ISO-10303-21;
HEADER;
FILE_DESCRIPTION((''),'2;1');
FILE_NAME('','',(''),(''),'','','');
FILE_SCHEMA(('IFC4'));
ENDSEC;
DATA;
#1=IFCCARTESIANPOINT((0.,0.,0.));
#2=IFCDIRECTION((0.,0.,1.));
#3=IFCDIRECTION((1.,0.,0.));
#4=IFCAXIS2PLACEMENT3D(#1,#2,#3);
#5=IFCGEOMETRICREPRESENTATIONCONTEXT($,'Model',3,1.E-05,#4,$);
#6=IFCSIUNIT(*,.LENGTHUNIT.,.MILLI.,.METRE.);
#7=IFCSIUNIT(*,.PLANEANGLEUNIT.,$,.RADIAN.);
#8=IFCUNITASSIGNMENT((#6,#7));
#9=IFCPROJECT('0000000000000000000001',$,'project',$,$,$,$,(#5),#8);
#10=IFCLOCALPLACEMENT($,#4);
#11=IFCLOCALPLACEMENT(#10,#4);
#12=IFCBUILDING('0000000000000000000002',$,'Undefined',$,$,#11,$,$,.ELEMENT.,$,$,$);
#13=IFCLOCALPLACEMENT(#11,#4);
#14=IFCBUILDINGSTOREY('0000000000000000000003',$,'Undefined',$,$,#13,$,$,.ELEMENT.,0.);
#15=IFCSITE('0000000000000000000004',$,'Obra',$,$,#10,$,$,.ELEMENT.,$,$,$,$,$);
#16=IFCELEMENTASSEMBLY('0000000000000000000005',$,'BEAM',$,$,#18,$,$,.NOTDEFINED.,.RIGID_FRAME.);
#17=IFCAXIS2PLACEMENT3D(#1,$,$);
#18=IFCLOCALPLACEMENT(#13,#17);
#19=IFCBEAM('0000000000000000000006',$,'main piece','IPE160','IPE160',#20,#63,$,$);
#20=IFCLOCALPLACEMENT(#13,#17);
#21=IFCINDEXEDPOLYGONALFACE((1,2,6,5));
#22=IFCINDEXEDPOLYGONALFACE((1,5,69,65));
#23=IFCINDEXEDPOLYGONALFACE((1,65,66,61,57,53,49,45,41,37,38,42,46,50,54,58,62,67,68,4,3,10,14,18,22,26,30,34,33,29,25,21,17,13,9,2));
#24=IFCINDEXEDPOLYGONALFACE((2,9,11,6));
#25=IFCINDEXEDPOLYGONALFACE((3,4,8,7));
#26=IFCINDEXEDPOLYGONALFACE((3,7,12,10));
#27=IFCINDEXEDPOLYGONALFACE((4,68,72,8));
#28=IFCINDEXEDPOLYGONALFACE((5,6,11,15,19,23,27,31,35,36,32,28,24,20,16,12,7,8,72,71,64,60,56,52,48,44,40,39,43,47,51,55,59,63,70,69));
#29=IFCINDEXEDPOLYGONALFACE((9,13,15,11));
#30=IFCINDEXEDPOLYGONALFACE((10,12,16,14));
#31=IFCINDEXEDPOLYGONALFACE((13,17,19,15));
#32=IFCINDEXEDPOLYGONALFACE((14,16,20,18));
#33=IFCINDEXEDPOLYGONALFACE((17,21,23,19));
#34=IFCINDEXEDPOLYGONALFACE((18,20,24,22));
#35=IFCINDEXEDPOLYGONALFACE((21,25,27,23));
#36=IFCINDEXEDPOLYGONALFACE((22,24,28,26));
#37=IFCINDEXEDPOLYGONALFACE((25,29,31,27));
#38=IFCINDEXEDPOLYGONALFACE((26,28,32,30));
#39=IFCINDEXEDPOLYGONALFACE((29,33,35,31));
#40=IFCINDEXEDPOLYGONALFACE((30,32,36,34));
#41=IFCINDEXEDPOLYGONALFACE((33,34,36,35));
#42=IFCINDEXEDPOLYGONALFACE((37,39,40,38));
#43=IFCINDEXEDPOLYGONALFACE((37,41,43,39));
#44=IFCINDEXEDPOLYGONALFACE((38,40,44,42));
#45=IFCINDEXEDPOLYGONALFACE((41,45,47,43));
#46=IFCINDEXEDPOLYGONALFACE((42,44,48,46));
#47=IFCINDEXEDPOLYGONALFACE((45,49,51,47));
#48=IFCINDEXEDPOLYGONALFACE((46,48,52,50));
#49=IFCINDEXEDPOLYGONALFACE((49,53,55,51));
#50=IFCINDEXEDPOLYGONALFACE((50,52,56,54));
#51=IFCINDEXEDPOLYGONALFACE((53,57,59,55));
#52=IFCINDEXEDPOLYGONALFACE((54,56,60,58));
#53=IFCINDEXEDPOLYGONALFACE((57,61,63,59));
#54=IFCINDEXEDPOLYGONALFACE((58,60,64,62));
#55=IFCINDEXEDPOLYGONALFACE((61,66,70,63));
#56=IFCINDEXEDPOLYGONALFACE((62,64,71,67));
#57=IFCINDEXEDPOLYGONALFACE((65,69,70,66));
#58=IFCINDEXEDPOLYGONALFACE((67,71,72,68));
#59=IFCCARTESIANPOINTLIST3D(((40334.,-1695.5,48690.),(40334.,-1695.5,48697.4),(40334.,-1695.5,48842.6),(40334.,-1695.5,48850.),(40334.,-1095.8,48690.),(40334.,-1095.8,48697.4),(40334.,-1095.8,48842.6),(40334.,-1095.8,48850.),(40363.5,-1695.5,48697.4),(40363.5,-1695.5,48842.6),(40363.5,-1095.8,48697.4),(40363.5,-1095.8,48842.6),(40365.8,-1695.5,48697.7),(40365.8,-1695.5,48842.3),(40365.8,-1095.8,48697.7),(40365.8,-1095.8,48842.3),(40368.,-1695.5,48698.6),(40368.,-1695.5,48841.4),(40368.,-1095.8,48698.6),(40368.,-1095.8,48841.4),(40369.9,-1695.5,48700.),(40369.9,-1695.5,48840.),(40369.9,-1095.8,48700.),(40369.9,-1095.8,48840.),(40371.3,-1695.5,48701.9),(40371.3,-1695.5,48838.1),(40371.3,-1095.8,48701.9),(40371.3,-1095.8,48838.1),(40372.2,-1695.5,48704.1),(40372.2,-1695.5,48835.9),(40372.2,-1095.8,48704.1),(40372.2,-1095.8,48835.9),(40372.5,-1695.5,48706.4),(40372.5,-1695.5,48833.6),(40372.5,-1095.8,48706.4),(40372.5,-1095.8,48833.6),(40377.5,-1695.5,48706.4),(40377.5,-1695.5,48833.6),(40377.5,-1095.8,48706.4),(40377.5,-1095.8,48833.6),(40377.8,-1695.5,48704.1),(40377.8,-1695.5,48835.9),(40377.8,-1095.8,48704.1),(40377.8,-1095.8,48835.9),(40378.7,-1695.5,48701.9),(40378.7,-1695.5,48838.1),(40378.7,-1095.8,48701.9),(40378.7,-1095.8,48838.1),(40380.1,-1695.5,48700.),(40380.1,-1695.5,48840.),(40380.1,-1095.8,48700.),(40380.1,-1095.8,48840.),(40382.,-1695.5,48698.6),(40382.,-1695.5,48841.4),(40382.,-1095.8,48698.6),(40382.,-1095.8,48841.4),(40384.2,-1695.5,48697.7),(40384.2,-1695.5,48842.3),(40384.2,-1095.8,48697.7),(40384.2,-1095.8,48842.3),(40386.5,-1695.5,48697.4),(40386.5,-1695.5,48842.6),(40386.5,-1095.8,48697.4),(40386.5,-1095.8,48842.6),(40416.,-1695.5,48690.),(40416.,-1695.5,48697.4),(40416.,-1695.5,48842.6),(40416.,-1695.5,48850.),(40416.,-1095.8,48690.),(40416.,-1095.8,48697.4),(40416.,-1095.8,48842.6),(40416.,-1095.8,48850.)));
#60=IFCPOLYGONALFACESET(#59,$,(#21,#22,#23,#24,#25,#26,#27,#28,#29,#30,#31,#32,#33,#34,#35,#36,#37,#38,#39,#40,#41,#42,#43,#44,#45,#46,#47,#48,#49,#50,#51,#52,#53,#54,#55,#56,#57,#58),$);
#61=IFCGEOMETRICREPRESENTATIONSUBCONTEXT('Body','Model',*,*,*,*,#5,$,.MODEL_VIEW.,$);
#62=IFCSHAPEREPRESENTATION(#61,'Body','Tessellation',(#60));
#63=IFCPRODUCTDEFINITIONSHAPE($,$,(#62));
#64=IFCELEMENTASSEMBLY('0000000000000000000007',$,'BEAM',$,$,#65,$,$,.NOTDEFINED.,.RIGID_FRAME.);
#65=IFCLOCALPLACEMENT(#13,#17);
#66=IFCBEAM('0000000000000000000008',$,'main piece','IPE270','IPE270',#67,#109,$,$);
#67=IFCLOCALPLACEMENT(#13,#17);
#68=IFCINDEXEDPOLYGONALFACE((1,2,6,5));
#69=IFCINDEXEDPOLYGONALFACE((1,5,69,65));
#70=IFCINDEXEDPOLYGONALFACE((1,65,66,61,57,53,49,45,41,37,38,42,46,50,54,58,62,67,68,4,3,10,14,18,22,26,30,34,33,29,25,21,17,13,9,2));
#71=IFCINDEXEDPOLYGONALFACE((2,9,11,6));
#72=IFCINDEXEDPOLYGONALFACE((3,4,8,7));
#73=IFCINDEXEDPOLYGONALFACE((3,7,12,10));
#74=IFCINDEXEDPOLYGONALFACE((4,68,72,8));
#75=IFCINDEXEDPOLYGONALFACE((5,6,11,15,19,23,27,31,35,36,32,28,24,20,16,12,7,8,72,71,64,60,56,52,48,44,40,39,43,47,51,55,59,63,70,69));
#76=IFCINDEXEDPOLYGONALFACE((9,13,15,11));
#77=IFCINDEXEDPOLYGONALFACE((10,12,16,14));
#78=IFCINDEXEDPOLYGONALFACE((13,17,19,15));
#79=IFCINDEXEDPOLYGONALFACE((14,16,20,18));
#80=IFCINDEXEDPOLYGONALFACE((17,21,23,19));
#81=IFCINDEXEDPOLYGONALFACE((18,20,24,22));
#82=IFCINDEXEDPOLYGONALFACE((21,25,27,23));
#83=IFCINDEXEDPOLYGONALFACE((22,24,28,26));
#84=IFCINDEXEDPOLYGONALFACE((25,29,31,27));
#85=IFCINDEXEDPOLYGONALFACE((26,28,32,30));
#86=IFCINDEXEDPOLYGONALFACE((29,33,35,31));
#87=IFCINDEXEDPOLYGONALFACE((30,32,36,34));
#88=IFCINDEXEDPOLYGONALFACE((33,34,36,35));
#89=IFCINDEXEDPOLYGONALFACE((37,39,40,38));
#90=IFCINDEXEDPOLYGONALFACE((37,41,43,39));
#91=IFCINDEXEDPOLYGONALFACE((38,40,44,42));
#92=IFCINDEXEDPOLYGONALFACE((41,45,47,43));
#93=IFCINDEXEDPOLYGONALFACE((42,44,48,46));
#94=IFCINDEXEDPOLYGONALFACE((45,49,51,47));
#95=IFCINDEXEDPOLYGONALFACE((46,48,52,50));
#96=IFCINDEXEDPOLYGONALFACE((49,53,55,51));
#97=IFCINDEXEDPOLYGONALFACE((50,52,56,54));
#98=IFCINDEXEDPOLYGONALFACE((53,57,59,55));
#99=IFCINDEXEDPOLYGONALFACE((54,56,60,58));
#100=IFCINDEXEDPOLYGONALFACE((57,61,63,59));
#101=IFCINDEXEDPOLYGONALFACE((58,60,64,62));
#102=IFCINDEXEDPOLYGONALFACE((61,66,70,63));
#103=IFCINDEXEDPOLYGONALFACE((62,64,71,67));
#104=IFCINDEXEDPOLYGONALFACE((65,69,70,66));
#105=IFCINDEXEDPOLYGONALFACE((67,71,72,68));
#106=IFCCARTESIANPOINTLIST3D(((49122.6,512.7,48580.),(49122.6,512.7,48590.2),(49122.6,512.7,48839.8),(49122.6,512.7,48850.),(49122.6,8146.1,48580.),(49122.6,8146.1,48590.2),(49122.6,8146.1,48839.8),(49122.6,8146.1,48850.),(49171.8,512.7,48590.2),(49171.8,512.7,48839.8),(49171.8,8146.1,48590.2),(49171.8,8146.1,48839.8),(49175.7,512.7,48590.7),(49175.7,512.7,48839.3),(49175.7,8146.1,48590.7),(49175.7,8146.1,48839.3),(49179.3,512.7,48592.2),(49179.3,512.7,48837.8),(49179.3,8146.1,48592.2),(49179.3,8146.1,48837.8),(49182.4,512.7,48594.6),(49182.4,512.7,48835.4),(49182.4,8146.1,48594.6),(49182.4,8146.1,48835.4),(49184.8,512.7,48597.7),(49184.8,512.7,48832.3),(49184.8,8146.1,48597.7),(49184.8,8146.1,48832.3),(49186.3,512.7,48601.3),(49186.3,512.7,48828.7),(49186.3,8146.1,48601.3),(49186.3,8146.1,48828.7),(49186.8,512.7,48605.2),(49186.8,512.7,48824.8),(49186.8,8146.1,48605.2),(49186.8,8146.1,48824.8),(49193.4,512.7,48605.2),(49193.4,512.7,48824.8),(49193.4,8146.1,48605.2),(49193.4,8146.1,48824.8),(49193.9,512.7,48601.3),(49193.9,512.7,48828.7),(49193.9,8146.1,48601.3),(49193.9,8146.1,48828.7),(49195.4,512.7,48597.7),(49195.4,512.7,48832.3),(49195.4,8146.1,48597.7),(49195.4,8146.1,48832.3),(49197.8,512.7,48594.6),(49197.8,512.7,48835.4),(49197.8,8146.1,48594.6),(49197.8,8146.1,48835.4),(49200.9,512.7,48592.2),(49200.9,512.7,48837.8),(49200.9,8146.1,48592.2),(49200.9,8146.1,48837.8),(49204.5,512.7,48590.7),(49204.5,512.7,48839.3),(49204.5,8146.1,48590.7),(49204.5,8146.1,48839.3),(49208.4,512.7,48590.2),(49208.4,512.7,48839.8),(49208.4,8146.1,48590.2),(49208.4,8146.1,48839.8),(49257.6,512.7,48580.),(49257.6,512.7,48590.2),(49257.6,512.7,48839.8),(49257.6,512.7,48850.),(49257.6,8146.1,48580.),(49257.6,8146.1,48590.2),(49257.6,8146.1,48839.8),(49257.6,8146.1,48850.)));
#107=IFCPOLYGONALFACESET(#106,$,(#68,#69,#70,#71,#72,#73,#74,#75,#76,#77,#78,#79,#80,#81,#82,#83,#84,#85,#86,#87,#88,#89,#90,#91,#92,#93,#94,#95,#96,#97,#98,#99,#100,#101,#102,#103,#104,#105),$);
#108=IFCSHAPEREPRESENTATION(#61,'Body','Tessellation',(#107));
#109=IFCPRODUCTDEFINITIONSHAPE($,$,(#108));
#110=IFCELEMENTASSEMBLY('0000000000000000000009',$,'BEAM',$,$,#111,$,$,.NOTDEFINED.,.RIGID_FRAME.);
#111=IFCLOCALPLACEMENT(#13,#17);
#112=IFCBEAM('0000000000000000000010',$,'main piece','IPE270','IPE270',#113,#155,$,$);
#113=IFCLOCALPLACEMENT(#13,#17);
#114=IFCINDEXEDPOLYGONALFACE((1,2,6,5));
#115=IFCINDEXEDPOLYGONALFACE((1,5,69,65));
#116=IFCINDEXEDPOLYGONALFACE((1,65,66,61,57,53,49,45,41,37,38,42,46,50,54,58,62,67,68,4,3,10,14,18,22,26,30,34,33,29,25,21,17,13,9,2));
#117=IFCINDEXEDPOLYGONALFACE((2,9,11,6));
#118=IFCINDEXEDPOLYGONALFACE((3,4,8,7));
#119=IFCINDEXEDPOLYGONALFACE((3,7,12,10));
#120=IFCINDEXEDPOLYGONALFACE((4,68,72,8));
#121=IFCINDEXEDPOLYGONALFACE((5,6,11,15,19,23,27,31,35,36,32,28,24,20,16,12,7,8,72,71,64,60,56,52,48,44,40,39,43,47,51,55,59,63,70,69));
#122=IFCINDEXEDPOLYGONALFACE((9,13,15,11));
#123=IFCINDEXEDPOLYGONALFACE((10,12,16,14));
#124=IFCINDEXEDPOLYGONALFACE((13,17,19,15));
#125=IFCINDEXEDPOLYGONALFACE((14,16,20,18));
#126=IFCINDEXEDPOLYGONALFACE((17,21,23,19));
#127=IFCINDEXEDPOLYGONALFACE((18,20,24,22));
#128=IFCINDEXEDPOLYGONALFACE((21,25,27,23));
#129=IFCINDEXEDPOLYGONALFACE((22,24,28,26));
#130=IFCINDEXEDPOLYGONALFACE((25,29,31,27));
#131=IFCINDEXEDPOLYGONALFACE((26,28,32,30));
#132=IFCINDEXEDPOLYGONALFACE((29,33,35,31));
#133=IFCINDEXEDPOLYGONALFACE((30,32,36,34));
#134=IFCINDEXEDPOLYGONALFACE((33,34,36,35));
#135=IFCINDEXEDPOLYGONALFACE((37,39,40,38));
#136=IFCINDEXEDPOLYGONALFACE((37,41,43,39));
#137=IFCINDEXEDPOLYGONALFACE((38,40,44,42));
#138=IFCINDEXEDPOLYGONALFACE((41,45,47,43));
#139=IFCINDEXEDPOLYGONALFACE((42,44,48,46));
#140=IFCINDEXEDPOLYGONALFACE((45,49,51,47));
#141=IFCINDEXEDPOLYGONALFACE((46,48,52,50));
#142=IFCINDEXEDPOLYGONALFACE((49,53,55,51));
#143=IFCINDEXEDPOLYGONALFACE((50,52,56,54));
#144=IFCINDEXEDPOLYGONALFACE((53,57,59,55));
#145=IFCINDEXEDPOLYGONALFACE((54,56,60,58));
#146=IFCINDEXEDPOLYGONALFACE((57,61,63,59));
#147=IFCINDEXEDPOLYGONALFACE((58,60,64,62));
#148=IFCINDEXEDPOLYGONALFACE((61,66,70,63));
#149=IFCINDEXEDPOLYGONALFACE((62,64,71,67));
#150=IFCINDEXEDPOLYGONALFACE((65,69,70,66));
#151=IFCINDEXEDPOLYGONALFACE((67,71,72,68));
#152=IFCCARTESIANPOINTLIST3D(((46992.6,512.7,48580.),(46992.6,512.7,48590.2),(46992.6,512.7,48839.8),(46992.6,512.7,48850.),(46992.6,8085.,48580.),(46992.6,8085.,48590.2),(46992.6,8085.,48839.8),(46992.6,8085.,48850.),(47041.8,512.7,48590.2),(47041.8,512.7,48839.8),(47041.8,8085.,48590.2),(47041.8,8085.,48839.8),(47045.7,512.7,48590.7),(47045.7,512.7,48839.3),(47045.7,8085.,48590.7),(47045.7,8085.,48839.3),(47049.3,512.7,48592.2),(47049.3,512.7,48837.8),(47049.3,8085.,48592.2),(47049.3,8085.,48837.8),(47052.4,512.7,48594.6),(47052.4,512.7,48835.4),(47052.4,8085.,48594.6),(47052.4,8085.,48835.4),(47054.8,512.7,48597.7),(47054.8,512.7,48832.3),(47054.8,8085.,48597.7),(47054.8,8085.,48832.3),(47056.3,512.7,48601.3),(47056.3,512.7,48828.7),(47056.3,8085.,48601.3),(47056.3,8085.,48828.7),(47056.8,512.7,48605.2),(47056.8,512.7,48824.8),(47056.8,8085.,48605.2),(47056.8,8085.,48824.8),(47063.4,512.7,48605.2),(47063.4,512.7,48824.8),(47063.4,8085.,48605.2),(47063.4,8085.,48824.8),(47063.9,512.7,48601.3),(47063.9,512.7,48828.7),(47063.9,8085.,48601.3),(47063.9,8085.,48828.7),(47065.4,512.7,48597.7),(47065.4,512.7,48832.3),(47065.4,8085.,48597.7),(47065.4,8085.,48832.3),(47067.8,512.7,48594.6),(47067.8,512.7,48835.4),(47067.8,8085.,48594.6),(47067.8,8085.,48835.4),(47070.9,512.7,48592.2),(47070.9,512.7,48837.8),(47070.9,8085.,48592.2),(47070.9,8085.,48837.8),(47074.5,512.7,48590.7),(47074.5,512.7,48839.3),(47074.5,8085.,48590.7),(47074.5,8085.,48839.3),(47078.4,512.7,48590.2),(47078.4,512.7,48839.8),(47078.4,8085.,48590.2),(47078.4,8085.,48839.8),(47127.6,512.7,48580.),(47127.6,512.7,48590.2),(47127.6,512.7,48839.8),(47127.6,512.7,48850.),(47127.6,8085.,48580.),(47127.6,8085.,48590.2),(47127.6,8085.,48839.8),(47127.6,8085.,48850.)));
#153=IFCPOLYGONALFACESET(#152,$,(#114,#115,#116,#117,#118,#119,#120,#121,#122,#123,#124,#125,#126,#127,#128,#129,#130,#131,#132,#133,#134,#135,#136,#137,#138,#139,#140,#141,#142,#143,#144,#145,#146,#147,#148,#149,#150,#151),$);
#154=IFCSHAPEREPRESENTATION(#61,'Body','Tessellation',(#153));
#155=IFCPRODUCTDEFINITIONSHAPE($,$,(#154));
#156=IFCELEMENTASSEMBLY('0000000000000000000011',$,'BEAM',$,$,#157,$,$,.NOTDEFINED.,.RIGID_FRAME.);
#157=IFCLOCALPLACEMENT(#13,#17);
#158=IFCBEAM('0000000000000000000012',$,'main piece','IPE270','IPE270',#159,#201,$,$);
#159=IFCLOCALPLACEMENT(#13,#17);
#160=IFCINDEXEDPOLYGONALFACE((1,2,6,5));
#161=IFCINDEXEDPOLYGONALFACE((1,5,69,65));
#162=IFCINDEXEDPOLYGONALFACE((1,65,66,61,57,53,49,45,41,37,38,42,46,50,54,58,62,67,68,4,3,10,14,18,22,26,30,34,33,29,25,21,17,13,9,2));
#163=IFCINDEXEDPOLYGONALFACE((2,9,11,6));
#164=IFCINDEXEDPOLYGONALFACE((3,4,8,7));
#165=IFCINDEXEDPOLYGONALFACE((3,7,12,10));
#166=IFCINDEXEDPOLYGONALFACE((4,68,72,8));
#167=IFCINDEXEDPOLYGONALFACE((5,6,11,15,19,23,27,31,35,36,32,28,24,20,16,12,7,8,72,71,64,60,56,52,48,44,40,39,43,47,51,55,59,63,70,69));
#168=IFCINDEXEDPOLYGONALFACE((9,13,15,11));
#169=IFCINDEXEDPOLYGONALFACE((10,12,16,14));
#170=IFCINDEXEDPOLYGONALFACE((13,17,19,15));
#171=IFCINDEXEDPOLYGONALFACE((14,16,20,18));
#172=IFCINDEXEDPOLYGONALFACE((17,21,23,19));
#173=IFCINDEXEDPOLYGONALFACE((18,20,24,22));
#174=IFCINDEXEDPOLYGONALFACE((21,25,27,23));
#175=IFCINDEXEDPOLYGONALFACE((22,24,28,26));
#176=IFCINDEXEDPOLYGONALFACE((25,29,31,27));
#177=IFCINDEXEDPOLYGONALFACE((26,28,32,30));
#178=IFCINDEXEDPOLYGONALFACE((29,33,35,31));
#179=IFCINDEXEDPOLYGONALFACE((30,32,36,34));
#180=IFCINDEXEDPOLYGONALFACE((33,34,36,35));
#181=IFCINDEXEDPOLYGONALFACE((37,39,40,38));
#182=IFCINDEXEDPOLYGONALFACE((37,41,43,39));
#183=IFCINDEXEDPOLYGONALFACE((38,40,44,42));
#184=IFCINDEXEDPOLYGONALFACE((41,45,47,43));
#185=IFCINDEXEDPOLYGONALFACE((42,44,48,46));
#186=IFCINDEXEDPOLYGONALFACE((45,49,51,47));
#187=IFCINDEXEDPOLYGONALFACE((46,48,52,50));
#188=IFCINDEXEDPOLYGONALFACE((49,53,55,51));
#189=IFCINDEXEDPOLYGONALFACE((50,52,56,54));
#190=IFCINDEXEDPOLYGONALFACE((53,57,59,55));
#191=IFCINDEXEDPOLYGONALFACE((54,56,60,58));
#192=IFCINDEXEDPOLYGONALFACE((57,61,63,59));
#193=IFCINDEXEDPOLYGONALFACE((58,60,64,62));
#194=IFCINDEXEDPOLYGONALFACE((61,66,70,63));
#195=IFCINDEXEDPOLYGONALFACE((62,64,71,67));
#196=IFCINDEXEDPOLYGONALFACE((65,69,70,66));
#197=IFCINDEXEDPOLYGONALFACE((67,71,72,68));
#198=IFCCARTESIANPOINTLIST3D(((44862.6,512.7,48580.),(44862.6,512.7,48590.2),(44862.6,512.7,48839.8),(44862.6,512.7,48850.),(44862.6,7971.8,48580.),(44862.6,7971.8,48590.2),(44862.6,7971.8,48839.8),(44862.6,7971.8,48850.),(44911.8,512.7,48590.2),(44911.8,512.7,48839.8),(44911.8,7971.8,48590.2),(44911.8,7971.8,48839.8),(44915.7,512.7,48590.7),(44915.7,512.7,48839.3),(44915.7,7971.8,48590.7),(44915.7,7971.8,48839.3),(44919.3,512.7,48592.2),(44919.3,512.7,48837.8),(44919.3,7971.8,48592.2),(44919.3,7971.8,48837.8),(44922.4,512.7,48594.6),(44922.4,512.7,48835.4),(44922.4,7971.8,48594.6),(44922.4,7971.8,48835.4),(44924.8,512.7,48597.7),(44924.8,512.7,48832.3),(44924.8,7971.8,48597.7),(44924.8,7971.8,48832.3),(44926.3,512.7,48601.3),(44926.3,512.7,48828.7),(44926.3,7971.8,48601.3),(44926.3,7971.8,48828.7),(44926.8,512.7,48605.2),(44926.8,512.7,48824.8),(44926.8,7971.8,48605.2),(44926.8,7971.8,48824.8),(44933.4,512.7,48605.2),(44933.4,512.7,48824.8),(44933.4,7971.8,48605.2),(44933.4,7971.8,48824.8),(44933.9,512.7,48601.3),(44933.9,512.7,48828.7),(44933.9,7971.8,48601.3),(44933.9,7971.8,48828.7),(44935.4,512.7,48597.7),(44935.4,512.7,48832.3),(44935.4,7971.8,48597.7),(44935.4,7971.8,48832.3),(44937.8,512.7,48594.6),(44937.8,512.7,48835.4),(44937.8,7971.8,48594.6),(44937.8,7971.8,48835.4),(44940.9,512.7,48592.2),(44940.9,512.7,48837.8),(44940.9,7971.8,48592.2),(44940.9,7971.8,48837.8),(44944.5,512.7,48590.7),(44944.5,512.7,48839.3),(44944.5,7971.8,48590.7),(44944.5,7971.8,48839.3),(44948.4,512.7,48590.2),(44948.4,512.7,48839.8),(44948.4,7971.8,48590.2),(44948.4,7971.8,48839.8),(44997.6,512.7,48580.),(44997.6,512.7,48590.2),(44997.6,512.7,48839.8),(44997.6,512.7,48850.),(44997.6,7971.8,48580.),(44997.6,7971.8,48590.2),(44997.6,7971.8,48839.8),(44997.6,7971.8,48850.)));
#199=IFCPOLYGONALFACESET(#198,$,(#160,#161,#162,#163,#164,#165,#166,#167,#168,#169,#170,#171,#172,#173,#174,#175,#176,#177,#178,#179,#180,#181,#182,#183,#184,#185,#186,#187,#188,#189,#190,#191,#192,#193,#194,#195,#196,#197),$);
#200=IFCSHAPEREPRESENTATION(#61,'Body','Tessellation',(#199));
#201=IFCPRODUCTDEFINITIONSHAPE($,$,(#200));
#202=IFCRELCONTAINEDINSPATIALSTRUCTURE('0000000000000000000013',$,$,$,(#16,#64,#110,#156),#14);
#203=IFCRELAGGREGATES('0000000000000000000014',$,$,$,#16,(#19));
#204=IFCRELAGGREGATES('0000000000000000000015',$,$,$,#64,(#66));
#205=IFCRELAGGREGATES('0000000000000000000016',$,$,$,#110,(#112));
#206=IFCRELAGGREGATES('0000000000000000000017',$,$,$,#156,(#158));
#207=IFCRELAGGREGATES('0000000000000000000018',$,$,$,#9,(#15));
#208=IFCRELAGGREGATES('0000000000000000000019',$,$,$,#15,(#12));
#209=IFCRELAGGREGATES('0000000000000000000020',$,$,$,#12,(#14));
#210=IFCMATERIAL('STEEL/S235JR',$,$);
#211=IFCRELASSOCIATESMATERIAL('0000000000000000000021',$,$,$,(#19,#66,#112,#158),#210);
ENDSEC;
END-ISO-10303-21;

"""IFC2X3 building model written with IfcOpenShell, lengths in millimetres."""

from ifc_helpers import new_model, si_unit, frame, origin_with_axes, origin_2d_with_axis, place, context, subcontext, project, spatial, i_section, extrude, material, element, aggregate, save


model = new_model("IFC2X3")

# Units and contexts
model_context = context("Model", 3, precision=1e-05, world=origin_with_axes())
body_context = subcontext(model_context, "Body", "Model", "MODEL_VIEW")
ifc_project = project(units=[si_unit("LENGTHUNIT", "METRE", prefix="MILLI"), si_unit("PLANEANGLEUNIT", "RADIAN")], contexts=[model_context])

# Site, building, storey
site_placement = place(None, origin_with_axes())
site = spatial("IfcSite", under=ifc_project, at=site_placement, Name="Obra", CompositionType="ELEMENT")
building_placement = place(site_placement, origin_with_axes())
building = spatial("IfcBuilding", under=site, at=building_placement, Name="Undefined", CompositionType="ELEMENT")
storey_placement = place(building_placement, origin_with_axes())
storey = spatial("IfcBuildingStorey", under=building, at=storey_placement, Name="Undefined", CompositionType="ELEMENT", Elevation=0.0)

# Shared definitions
ifc_material_1 = material(Name="STEEL/S235JR")

# Element assemblies, beams
assembly_1_placement = place(storey_placement, origin_with_axes())
assembly_1 = element("IfcElementAssembly", 1, at=assembly_1_placement, inside=storey, Name="BEAM", AssemblyPlace="NOTDEFINED", PredefinedType="RIGID_FRAME")
beam_1_placement = place(assembly_1_placement, frame((40375.0, -1695.5, 48770.0), z_axis=(0.0, 0.0, 1.0), x_axis=(0.0, 1.0, 0.0)))
beam_1 = element("IfcBeam", 2, at=beam_1_placement, material=ifc_material_1, Name="main piece", Description="IPE160", ObjectType="IPE160", context=body_context, shape_type="SweptSolid", body=[
    extrude(i_section(OverallWidth=82.0, OverallDepth=160.0, WebThickness=5.0, FlangeThickness=7.4, FilletRadius=9.0, at=origin_2d_with_axis()), frame((599.7, 0.0, 0.0), z_axis=(-1.0, 0.0, 0.0), x_axis=(0.0, -1.0, 0.0)), (0.0, 0.0, 1.0), 599.7),
])
aggregate(assembly_1, [beam_1])
assembly_2_placement = place(storey_placement, origin_with_axes())
assembly_2 = element("IfcElementAssembly", 3, at=assembly_2_placement, inside=storey, Name="BEAM", AssemblyPlace="NOTDEFINED", PredefinedType="RIGID_FRAME")
beam_2_placement = place(assembly_2_placement, frame((49190.1, 512.7, 48715.0), z_axis=(0.0, 0.0, 1.0), x_axis=(0.0, 1.0, 0.0)))
beam_2 = element("IfcBeam", 4, at=beam_2_placement, material=ifc_material_1, Name="main piece", Description="IPE270", ObjectType="IPE270", context=body_context, shape_type="SweptSolid", body=[
    extrude(i_section(OverallWidth=135.0, OverallDepth=270.0, WebThickness=6.6, FlangeThickness=10.2, FilletRadius=15.0, at=origin_2d_with_axis()), frame((7633.4, 0.0, 0.0), z_axis=(-1.0, 0.0, 0.0), x_axis=(0.0, -1.0, 0.0)), (0.0, 0.0, 1.0), 7633.4),
])
aggregate(assembly_2, [beam_2])
assembly_3_placement = place(storey_placement, origin_with_axes())
assembly_3 = element("IfcElementAssembly", 5, at=assembly_3_placement, inside=storey, Name="BEAM", AssemblyPlace="NOTDEFINED", PredefinedType="RIGID_FRAME")
beam_3_placement = place(assembly_3_placement, frame((47060.1, 8085.0, 48715.0), z_axis=(0.0, 0.0, 1.0), x_axis=(0.0, -1.0, 0.0)))
beam_3 = element("IfcBeam", 6, at=beam_3_placement, material=ifc_material_1, Name="main piece", Description="IPE270", ObjectType="IPE270", context=body_context, shape_type="SweptSolid", body=[
    extrude(i_section(OverallWidth=135.0, OverallDepth=270.0, WebThickness=6.6, FlangeThickness=10.2, FilletRadius=15.0, at=origin_2d_with_axis()), frame((7572.3, 0.0, 0.0), z_axis=(-1.0, 0.0, 0.0), x_axis=(0.0, -1.0, 0.0)), (0.0, 0.0, 1.0), 7572.3),
])
aggregate(assembly_3, [beam_3])
assembly_4_placement = place(storey_placement, origin_with_axes())
assembly_4 = element("IfcElementAssembly", 7, at=assembly_4_placement, inside=storey, Name="BEAM", AssemblyPlace="NOTDEFINED", PredefinedType="RIGID_FRAME")
beam_4_placement = place(assembly_4_placement, frame((44930.1, 512.7, 48715.0), z_axis=(0.0, 0.0, 1.0), x_axis=(0.0, 1.0, 0.0)))
beam_4 = element("IfcBeam", 8, at=beam_4_placement, material=ifc_material_1, Name="main piece", Description="IPE270", ObjectType="IPE270", context=body_context, shape_type="SweptSolid", body=[
    extrude(i_section(OverallWidth=135.0, OverallDepth=270.0, WebThickness=6.6, FlangeThickness=10.2, FilletRadius=15.0, at=origin_2d_with_axis()), frame((7459.1, 0.0, 0.0), z_axis=(-1.0, 0.0, 0.0), x_axis=(0.0, -1.0, 0.0)), (0.0, 0.0, 1.0), 7459.1),
])
aggregate(assembly_4, [beam_4])

save(model, "model.ifc")
